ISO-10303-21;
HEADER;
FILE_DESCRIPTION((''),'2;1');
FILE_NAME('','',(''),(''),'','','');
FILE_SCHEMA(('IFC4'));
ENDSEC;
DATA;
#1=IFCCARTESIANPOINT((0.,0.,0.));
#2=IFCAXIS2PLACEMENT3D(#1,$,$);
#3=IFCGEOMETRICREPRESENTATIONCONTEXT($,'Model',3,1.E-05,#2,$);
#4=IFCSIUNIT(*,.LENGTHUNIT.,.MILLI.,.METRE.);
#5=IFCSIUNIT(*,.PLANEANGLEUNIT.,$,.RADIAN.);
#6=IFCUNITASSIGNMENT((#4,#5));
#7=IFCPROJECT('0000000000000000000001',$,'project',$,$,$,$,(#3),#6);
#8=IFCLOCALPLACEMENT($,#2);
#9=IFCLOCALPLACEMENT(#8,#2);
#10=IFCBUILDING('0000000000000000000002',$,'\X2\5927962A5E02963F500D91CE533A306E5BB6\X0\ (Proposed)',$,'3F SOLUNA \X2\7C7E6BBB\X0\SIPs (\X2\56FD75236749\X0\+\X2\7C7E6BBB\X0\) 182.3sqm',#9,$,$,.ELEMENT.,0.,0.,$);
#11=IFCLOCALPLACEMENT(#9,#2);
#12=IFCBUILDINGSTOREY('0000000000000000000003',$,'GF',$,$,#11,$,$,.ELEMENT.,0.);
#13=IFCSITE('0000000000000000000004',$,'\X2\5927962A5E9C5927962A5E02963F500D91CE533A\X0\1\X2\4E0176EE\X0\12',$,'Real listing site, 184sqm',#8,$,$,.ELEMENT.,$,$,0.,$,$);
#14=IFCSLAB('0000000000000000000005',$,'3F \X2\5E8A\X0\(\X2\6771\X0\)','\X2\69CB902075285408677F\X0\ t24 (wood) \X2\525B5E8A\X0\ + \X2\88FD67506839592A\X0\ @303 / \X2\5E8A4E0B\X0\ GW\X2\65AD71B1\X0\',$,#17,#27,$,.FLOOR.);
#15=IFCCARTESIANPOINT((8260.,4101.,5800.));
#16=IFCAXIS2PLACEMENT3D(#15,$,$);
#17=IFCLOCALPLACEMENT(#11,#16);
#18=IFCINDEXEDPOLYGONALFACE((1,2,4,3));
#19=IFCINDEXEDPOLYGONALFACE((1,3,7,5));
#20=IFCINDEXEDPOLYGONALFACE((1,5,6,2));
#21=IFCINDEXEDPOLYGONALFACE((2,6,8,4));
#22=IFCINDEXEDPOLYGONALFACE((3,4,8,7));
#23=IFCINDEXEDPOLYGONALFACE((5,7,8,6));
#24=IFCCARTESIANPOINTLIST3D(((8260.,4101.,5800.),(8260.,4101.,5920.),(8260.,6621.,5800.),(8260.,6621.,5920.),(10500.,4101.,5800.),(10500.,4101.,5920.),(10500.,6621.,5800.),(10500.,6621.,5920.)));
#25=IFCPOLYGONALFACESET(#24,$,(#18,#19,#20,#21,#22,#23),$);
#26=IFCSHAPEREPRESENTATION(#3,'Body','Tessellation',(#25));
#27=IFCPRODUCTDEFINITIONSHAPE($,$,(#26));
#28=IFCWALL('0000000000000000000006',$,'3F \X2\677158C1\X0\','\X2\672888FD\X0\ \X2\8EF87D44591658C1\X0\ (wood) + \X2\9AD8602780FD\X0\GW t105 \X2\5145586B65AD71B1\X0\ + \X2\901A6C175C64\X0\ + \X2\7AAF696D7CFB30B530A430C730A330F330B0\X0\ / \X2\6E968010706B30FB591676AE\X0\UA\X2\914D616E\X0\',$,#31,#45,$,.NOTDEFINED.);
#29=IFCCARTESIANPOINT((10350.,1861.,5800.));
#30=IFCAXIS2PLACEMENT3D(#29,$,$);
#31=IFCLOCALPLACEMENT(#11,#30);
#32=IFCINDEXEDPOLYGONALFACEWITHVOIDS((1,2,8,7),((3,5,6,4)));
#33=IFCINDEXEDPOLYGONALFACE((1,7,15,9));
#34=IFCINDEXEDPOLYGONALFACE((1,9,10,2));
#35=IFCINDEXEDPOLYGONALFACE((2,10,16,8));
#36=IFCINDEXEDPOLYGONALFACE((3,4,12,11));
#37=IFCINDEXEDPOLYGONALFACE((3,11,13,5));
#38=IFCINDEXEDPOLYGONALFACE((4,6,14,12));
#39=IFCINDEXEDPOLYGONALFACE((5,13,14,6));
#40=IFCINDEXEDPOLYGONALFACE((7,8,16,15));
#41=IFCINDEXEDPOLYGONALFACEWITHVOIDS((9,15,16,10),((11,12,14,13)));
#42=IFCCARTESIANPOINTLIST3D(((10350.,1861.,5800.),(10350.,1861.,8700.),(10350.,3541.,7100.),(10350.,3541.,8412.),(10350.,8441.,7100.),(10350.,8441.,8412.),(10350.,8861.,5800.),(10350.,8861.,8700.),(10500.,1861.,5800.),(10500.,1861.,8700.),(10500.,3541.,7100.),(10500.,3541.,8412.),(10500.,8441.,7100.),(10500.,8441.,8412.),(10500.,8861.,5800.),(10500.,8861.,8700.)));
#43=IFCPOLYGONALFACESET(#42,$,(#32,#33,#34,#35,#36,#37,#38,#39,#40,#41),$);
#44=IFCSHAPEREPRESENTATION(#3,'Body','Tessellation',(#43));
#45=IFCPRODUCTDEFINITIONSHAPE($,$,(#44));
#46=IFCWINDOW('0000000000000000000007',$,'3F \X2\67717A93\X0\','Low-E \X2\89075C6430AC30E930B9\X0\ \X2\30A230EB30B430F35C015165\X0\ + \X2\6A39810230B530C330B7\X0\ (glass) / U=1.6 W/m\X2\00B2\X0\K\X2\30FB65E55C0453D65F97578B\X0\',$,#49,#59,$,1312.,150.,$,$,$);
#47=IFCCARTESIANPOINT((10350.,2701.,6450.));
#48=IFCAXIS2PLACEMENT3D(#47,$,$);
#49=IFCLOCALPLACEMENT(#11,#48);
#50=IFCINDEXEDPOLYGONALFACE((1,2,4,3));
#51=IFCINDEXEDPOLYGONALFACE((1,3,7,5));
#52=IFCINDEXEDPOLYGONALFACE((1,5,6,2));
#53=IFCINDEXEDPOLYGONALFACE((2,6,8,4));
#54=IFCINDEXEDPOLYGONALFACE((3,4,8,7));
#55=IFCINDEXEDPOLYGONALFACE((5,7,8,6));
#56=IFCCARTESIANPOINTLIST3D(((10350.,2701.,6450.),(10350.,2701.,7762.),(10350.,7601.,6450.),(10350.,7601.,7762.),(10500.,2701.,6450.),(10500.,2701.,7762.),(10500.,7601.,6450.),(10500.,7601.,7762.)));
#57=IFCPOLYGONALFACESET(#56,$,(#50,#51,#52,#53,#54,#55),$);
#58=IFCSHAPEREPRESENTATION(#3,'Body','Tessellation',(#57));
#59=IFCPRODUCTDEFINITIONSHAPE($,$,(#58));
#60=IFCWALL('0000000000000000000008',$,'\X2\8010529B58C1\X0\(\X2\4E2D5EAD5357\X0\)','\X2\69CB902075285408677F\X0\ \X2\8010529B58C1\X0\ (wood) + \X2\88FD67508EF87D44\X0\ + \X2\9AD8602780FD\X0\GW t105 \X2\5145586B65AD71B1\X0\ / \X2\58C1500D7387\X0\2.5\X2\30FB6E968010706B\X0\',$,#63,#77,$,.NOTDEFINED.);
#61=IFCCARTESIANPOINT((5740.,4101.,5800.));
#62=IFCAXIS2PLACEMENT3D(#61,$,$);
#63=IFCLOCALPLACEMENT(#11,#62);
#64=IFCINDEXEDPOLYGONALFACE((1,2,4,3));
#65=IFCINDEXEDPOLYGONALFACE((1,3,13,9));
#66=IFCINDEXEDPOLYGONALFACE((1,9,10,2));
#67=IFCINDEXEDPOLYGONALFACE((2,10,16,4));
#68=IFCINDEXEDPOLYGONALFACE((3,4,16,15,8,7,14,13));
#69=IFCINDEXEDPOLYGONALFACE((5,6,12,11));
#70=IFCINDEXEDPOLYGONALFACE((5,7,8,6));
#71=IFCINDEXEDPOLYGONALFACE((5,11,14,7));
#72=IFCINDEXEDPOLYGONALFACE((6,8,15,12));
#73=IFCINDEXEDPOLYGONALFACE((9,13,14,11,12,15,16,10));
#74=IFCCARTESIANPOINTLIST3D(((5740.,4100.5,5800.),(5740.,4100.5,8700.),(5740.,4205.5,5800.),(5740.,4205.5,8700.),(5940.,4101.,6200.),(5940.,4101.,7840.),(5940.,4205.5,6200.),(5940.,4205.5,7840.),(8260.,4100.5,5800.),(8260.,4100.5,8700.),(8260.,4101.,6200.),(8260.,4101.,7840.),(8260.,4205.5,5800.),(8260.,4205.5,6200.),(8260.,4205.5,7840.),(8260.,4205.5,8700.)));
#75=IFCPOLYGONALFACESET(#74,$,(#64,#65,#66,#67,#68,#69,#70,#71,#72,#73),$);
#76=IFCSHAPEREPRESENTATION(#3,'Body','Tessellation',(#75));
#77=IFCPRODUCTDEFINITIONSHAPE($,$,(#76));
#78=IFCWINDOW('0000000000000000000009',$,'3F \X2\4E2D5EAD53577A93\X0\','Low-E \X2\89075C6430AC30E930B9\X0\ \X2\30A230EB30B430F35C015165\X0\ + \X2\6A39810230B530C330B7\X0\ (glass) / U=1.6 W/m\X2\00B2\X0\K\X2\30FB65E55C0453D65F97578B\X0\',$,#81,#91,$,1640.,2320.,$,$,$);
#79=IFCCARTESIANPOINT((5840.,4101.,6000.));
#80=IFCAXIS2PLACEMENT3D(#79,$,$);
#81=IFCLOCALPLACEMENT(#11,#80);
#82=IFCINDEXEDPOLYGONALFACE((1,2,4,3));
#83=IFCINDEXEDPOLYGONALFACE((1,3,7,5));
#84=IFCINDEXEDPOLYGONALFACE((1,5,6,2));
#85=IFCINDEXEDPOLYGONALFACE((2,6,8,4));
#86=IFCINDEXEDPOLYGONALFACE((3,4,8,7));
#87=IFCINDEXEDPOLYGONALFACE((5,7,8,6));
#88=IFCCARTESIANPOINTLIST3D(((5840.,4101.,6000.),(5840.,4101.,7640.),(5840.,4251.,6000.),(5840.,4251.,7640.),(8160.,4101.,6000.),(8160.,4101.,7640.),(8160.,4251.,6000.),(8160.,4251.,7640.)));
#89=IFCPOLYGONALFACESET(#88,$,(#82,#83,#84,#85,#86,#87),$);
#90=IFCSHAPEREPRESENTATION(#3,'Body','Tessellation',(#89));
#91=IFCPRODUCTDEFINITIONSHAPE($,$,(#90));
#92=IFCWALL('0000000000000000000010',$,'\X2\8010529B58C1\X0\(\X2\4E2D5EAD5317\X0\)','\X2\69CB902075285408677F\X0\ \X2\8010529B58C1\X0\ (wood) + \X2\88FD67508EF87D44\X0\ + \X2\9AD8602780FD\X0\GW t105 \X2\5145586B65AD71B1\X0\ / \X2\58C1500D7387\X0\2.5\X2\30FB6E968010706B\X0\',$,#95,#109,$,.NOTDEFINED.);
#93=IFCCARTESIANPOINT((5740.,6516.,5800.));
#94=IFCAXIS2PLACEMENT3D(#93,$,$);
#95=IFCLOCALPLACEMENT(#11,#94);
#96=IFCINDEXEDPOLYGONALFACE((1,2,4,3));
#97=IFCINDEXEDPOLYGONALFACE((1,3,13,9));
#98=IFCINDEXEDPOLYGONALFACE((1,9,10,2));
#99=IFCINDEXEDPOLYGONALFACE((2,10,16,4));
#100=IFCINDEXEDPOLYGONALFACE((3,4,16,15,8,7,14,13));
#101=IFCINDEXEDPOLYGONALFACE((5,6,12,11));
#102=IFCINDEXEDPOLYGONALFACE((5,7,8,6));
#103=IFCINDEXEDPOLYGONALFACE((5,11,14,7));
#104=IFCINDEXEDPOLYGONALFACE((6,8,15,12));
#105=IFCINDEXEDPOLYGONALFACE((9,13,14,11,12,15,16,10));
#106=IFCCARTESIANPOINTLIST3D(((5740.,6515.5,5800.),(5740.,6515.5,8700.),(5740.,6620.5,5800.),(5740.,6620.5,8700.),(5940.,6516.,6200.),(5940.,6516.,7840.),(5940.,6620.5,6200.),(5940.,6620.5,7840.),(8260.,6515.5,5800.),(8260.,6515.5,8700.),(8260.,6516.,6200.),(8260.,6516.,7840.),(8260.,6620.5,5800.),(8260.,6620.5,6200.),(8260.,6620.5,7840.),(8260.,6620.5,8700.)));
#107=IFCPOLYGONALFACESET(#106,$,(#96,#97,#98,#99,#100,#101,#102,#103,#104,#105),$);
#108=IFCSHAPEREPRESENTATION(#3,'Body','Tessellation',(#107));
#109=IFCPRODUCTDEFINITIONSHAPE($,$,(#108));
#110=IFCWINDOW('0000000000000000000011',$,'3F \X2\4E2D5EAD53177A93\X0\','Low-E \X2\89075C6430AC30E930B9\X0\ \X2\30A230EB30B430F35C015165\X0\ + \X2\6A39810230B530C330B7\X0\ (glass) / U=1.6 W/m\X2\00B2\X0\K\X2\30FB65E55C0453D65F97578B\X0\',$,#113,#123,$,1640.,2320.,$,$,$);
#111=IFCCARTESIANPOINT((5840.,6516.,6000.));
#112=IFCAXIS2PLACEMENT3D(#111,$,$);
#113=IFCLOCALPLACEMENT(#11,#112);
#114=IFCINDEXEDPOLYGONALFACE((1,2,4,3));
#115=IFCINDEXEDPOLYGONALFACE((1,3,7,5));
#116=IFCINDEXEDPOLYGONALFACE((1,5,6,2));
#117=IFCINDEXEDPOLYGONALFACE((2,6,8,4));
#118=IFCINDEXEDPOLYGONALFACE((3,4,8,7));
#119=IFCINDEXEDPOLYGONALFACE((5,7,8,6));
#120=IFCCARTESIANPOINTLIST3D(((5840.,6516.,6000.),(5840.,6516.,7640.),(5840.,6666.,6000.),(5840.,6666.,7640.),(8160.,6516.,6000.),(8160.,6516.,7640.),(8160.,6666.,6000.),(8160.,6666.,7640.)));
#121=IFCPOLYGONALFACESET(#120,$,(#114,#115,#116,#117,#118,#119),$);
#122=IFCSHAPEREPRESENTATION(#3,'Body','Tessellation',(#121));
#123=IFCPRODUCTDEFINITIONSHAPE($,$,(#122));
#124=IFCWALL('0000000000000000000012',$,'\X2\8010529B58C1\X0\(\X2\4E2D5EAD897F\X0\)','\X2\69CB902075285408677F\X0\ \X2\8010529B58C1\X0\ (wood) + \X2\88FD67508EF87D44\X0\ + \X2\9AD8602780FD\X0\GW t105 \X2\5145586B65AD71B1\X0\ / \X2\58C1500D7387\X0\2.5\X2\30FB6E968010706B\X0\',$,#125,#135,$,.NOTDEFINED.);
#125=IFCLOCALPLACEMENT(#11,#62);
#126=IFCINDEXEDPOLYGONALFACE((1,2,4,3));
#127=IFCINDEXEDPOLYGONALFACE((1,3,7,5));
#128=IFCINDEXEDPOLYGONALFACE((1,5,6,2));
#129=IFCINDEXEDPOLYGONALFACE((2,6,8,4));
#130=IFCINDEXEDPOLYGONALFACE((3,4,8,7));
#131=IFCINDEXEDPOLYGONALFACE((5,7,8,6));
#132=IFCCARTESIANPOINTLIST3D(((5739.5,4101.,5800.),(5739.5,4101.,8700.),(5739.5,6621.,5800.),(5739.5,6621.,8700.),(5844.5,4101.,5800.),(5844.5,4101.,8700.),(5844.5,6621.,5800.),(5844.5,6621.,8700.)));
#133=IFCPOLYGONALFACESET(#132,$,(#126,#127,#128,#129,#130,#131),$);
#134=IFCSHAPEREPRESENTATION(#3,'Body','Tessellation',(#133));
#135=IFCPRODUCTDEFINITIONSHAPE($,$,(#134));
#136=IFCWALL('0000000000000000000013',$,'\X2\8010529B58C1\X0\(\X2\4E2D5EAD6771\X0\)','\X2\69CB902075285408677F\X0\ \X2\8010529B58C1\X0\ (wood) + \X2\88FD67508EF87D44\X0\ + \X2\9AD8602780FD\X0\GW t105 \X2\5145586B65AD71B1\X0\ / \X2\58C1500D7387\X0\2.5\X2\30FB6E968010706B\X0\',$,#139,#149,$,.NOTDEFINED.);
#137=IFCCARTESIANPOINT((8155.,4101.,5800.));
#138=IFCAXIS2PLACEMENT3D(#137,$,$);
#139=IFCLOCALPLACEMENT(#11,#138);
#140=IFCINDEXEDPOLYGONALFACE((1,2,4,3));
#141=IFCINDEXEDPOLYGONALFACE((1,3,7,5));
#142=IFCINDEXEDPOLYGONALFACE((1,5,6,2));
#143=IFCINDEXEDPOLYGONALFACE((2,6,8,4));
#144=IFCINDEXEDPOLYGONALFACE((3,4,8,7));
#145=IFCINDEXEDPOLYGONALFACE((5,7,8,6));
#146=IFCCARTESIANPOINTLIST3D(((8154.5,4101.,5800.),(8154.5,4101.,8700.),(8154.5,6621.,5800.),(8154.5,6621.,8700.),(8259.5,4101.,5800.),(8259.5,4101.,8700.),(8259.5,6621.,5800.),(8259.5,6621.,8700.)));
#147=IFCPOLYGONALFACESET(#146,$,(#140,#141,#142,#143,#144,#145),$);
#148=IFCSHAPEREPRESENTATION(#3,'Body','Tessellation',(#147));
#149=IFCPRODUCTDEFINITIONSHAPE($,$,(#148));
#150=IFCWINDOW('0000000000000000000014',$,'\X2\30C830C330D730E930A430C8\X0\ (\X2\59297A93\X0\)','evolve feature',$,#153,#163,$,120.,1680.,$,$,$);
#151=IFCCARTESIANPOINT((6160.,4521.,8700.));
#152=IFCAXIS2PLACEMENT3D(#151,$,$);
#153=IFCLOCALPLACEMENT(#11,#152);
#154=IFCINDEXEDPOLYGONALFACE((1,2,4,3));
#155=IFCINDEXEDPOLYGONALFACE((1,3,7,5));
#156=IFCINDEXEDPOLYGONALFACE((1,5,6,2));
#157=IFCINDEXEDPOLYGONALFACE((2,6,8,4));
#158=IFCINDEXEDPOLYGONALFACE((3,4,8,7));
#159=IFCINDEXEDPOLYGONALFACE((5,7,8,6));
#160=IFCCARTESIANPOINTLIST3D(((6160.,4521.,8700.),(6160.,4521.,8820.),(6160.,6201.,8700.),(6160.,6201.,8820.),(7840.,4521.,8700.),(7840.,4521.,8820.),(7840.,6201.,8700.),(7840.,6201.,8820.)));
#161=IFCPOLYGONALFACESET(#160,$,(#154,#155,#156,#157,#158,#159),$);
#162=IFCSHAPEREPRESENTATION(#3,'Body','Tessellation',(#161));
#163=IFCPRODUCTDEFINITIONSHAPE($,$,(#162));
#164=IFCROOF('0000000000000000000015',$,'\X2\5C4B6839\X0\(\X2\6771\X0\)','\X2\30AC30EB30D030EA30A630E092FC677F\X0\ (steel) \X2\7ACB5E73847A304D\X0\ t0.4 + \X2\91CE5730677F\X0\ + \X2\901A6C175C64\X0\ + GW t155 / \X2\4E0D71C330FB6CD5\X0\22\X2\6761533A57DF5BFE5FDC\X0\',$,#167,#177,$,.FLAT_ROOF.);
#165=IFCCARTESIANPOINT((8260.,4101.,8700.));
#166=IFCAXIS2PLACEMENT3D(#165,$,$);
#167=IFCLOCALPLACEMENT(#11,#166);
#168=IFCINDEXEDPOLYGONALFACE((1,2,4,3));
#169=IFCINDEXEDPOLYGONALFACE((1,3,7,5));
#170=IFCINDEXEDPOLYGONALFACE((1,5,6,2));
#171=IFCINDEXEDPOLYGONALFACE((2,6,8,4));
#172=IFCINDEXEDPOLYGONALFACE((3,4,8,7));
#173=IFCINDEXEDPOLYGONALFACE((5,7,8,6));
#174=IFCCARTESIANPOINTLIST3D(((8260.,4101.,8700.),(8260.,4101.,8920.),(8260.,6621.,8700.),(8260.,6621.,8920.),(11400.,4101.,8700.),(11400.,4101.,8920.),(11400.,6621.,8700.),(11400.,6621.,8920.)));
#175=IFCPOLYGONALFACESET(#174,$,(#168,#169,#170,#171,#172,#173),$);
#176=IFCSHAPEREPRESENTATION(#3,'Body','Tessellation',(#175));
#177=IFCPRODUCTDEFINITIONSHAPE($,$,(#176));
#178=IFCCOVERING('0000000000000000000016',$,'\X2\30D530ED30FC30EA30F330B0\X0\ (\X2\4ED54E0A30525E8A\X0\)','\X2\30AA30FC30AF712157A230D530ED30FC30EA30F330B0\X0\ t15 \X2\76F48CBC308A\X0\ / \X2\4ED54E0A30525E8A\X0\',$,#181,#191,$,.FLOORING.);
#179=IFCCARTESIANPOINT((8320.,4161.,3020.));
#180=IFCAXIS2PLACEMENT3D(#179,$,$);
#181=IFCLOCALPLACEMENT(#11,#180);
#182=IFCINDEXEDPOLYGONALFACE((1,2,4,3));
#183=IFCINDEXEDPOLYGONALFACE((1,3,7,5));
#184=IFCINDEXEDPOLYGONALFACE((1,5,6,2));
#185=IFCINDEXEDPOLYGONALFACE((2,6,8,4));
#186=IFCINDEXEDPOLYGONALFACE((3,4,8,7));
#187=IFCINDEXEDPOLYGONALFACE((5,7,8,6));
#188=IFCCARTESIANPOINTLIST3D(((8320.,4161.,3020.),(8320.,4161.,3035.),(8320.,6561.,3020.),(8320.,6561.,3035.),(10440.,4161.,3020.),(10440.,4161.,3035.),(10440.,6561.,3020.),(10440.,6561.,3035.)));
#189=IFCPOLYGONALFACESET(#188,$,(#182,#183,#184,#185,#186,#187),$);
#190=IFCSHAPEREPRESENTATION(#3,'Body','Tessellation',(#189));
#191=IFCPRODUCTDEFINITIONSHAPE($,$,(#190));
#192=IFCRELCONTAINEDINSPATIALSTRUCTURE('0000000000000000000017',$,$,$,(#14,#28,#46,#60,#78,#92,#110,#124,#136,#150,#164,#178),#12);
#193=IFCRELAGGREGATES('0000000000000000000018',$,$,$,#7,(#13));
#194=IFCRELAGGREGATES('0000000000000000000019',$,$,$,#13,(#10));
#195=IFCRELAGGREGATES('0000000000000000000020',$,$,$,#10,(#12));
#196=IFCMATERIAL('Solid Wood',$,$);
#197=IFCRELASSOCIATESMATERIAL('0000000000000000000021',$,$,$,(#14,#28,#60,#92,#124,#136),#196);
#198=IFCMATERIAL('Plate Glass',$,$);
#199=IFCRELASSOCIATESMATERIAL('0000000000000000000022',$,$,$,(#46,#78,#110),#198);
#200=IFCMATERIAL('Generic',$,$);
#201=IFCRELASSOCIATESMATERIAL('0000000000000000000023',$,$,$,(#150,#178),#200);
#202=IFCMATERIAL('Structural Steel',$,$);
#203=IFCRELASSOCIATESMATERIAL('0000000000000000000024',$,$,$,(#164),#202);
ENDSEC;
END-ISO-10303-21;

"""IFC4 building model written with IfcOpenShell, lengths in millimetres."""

from ifc_helpers import new_model, si_unit, frame, frame_2d, origin, place, context, project, spatial, rectangle, extrude, material, element, fill, save


model = new_model("IFC4")

# Units and contexts
model_context = context("Model", 3, precision=1e-05, world=origin())
ifc_project = project(units=[si_unit("LENGTHUNIT", "METRE", prefix="MILLI"), si_unit("PLANEANGLEUNIT", "RADIAN")], contexts=[model_context])

# Site, building, storey
site_placement = place(None, origin())
site = spatial("IfcSite", under=ifc_project, at=site_placement, Name="大阪府大阪市阿倍野区1丁目12", ObjectType="Real listing site, 184sqm", CompositionType="ELEMENT", RefElevation=0.0)
building_placement = place(site_placement, origin())
building = spatial("IfcBuilding", under=site, at=building_placement, Name="大阪市阿倍野区の家 (Proposed)", ObjectType="3F SOLUNA 籾殻SIPs (国産杉+籾殻) 182.3sqm", CompositionType="ELEMENT", ElevationOfRefHeight=0.0, ElevationOfTerrain=0.0)
storey_placement = place(building_placement, origin())
storey = spatial("IfcBuildingStorey", under=building, at=storey_placement, Name="GF", CompositionType="ELEMENT", Elevation=0.0)

# Slab
ifc_material_1 = material(Name="Solid Wood")
slab_placement = place(storey_placement, frame((8260.0, 4101.0, 5800.0)))
element("IfcSlab", 1, at=slab_placement, inside=storey, material=ifc_material_1, Name="3F 床(東)", Description="構造用合板 t24 (wood) 剛床 + 製材根太 @303 / 床下 GW断熱", PredefinedType="FLOOR", context=model_context, shape_type="SweptSolid", body=[
    extrude(rectangle(XDim=2240.0, YDim=2520.0, at=frame_2d((1120.0, 1260.0))), frame((8260.0, 4101.0, 5800.0)), (0.0, 0.0, 1.0), 120.0),
])

# Walls, openings, windows
wall_1_placement = place(storey_placement, frame((10350.0, 1861.0, 5800.0)))
wall_1 = element("IfcWall", 2, at=wall_1_placement, inside=storey, material=ifc_material_1, Name="3F 東壁", Description="木製 軸組外壁 (wood) + 高性能GW t105 充填断熱 + 通気層 + 窯業系サイディング / 準耐火・外皮UA配慮", PredefinedType="NOTDEFINED", context=model_context, shape_type="SweptSolid", body=[
    extrude(rectangle(XDim=150.0, YDim=7000.0, at=frame_2d((75.0, 3500.0))), frame((10350.0, 1861.0, 5800.0)), (0.0, 0.0, 1.0), 2900.0),
])
opening_1_placement = place(storey_placement, frame((10350.0, 2701.0, 6450.0)))
opening_1 = element("IfcOpeningElement", 3, at=opening_1_placement, cuts=wall_1, PredefinedType="NOTDEFINED", context=model_context, shape_type="SweptSolid", body=[
    extrude(rectangle(XDim=150.0, YDim=4900.0, at=frame_2d((75.0, 2450.0))), frame((10350.0, 2701.0, 6450.0)), (0.0, 0.0, 1.0), 1312.0),
])
ifc_material_2 = material(Name="Plate Glass")
window_1_placement = place(storey_placement, frame((10350.0, 2701.0, 6450.0)))
window_1 = element("IfcWindow", 4, at=window_1_placement, inside=storey, material=ifc_material_2, Name="3F 東窓", Description="Low-E 複層ガラス アルゴン封入 + 樹脂サッシ (glass) / U=1.6 W/m²K・日射取得型", OverallHeight=1312.0, OverallWidth=150.0, context=model_context, shape_type="SweptSolid", body=[
    extrude(rectangle(XDim=150.0, YDim=4900.0, at=frame_2d((75.0, 2450.0))), frame((10350.0, 2701.0, 6450.0)), (0.0, 0.0, 1.0), 1312.0),
])
fill(opening_1, window_1)
wall_2_placement = place(storey_placement, frame((5740.0, 4101.0, 5800.0)))
wall_2 = element("IfcWall", 5, at=wall_2_placement, inside=storey, material=ifc_material_1, Name="耐力壁(中庭南)", Description="構造用合板 耐力壁 (wood) + 製材軸組 + 高性能GW t105 充填断熱 / 壁倍率2.5・準耐火", PredefinedType="NOTDEFINED", context=model_context, shape_type="SweptSolid", body=[
    extrude(rectangle(XDim=2520.0, YDim=105.0, at=frame_2d((1260.0, 52.0))), frame((5740.0, 4101.0, 5800.0)), (0.0, 0.0, 1.0), 2900.0),
])
opening_2_placement = place(storey_placement, frame((5840.0, 4101.0, 6000.0)))
opening_2 = element("IfcOpeningElement", 6, at=opening_2_placement, cuts=wall_2, PredefinedType="NOTDEFINED", context=model_context, shape_type="SweptSolid", body=[
    extrude(rectangle(XDim=2320.0, YDim=150.0, at=frame_2d((1160.0, 75.0))), frame((5840.0, 4101.0, 6000.0)), (0.0, 0.0, 1.0), 1640.0),
])
window_2_placement = place(storey_placement, frame((5840.0, 4101.0, 6000.0)))
window_2 = element("IfcWindow", 7, at=window_2_placement, inside=storey, material=ifc_material_2, Name="3F 中庭南窓", Description="Low-E 複層ガラス アルゴン封入 + 樹脂サッシ (glass) / U=1.6 W/m²K・日射取得型", OverallHeight=1640.0, OverallWidth=2320.0, context=model_context, shape_type="SweptSolid", body=[
    extrude(rectangle(XDim=2320.0, YDim=150.0, at=frame_2d((1160.0, 75.0))), frame((5840.0, 4101.0, 6000.0)), (0.0, 0.0, 1.0), 1640.0),
])
fill(opening_2, window_2)
wall_3_placement = place(storey_placement, frame((5740.0, 6516.0, 5800.0)))
wall_3 = element("IfcWall", 8, at=wall_3_placement, inside=storey, material=ifc_material_1, Name="耐力壁(中庭北)", Description="構造用合板 耐力壁 (wood) + 製材軸組 + 高性能GW t105 充填断熱 / 壁倍率2.5・準耐火", PredefinedType="NOTDEFINED", context=model_context, shape_type="SweptSolid", body=[
    extrude(rectangle(XDim=2520.0, YDim=105.0, at=frame_2d((1260.0, 52.0))), frame((5740.0, 6516.0, 5800.0)), (0.0, 0.0, 1.0), 2900.0),
])
opening_3_placement = place(storey_placement, frame((5840.0, 6516.0, 6000.0)))
opening_3 = element("IfcOpeningElement", 9, at=opening_3_placement, cuts=wall_3, PredefinedType="NOTDEFINED", context=model_context, shape_type="SweptSolid", body=[
    extrude(rectangle(XDim=2320.0, YDim=150.0, at=frame_2d((1160.0, 75.0))), frame((5840.0, 6516.0, 6000.0)), (0.0, 0.0, 1.0), 1640.0),
])
window_3_placement = place(storey_placement, frame((5840.0, 6516.0, 6000.0)))
window_3 = element("IfcWindow", 10, at=window_3_placement, inside=storey, material=ifc_material_2, Name="3F 中庭北窓", Description="Low-E 複層ガラス アルゴン封入 + 樹脂サッシ (glass) / U=1.6 W/m²K・日射取得型", OverallHeight=1640.0, OverallWidth=2320.0, context=model_context, shape_type="SweptSolid", body=[
    extrude(rectangle(XDim=2320.0, YDim=150.0, at=frame_2d((1160.0, 75.0))), frame((5840.0, 6516.0, 6000.0)), (0.0, 0.0, 1.0), 1640.0),
])
fill(opening_3, window_3)

# Walls
wall_4_placement = place(storey_placement, frame((5740.0, 4101.0, 5800.0)))
element("IfcWall", 11, at=wall_4_placement, inside=storey, material=ifc_material_1, Name="耐力壁(中庭西)", Description="構造用合板 耐力壁 (wood) + 製材軸組 + 高性能GW t105 充填断熱 / 壁倍率2.5・準耐火", PredefinedType="NOTDEFINED", context=model_context, shape_type="SweptSolid", body=[
    extrude(rectangle(XDim=105.0, YDim=2520.0, at=frame_2d((52.0, 1260.0))), frame((5740.0, 4101.0, 5800.0)), (0.0, 0.0, 1.0), 2900.0),
])
wall_5_placement = place(storey_placement, frame((8155.0, 4101.0, 5800.0)))
element("IfcWall", 12, at=wall_5_placement, inside=storey, material=ifc_material_1, Name="耐力壁(中庭東)", Description="構造用合板 耐力壁 (wood) + 製材軸組 + 高性能GW t105 充填断熱 / 壁倍率2.5・準耐火", PredefinedType="NOTDEFINED", context=model_context, shape_type="SweptSolid", body=[
    extrude(rectangle(XDim=105.0, YDim=2520.0, at=frame_2d((52.0, 1260.0))), frame((8155.0, 4101.0, 5800.0)), (0.0, 0.0, 1.0), 2900.0),
])

# Window
ifc_material_3 = material(Name="Generic")
window_4_placement = place(storey_placement, frame((6160.0, 4521.0, 8700.0)))
element("IfcWindow", 13, at=window_4_placement, inside=storey, material=ifc_material_3, Name="トップライト (天窓)", Description="evolve feature", OverallHeight=120.0, OverallWidth=1680.0, context=model_context, shape_type="SweptSolid", body=[
    extrude(rectangle(XDim=1680.0, YDim=1680.0, at=frame_2d((840.0, 840.0))), frame((6160.0, 4521.0, 8700.0)), (0.0, 0.0, 1.0), 120.0),
])

# Roof
ifc_material_4 = material(Name="Structural Steel")
for number, where, name in (
    (14, (8260.0, 4101.0, 8700.0), "屋根(東)"),
):
    element("IfcRoof", number, at=place(storey_placement, frame(where)), inside=storey, material=ifc_material_4, Name=name, Description="ガルバリウム鋼板 (steel) 立平葺き t0.4 + 野地板 + 通気層 + GW t155 / 不燃・法22条区域対応", PredefinedType="FLAT_ROOF", context=model_context, shape_type="SweptSolid", body=[
        extrude(rectangle(XDim=3140.0, YDim=2520.0, at=frame_2d((1570.0, 1260.0))), frame((8260.0, 4101.0, 8700.0)), (0.0, 0.0, 1.0), 220.0),
    ])

# Covering
covering_1_placement = place(storey_placement, frame((8320.0, 4161.0, 3020.0)))
element("IfcCovering", 15, at=covering_1_placement, inside=storey, material=ifc_material_3, Name="フローリング (仕上げ床)", Description="オーク無垢フローリング t15 直貼り / 仕上げ床", PredefinedType="FLOORING", context=model_context, shape_type="SweptSolid", body=[
    extrude(rectangle(XDim=2120.0, YDim=2400.0, at=frame_2d((1060.0, 1200.0))), frame((8320.0, 4161.0, 3020.0)), (0.0, 0.0, 1.0), 15.0),
])

save(model, "model.ifc")
